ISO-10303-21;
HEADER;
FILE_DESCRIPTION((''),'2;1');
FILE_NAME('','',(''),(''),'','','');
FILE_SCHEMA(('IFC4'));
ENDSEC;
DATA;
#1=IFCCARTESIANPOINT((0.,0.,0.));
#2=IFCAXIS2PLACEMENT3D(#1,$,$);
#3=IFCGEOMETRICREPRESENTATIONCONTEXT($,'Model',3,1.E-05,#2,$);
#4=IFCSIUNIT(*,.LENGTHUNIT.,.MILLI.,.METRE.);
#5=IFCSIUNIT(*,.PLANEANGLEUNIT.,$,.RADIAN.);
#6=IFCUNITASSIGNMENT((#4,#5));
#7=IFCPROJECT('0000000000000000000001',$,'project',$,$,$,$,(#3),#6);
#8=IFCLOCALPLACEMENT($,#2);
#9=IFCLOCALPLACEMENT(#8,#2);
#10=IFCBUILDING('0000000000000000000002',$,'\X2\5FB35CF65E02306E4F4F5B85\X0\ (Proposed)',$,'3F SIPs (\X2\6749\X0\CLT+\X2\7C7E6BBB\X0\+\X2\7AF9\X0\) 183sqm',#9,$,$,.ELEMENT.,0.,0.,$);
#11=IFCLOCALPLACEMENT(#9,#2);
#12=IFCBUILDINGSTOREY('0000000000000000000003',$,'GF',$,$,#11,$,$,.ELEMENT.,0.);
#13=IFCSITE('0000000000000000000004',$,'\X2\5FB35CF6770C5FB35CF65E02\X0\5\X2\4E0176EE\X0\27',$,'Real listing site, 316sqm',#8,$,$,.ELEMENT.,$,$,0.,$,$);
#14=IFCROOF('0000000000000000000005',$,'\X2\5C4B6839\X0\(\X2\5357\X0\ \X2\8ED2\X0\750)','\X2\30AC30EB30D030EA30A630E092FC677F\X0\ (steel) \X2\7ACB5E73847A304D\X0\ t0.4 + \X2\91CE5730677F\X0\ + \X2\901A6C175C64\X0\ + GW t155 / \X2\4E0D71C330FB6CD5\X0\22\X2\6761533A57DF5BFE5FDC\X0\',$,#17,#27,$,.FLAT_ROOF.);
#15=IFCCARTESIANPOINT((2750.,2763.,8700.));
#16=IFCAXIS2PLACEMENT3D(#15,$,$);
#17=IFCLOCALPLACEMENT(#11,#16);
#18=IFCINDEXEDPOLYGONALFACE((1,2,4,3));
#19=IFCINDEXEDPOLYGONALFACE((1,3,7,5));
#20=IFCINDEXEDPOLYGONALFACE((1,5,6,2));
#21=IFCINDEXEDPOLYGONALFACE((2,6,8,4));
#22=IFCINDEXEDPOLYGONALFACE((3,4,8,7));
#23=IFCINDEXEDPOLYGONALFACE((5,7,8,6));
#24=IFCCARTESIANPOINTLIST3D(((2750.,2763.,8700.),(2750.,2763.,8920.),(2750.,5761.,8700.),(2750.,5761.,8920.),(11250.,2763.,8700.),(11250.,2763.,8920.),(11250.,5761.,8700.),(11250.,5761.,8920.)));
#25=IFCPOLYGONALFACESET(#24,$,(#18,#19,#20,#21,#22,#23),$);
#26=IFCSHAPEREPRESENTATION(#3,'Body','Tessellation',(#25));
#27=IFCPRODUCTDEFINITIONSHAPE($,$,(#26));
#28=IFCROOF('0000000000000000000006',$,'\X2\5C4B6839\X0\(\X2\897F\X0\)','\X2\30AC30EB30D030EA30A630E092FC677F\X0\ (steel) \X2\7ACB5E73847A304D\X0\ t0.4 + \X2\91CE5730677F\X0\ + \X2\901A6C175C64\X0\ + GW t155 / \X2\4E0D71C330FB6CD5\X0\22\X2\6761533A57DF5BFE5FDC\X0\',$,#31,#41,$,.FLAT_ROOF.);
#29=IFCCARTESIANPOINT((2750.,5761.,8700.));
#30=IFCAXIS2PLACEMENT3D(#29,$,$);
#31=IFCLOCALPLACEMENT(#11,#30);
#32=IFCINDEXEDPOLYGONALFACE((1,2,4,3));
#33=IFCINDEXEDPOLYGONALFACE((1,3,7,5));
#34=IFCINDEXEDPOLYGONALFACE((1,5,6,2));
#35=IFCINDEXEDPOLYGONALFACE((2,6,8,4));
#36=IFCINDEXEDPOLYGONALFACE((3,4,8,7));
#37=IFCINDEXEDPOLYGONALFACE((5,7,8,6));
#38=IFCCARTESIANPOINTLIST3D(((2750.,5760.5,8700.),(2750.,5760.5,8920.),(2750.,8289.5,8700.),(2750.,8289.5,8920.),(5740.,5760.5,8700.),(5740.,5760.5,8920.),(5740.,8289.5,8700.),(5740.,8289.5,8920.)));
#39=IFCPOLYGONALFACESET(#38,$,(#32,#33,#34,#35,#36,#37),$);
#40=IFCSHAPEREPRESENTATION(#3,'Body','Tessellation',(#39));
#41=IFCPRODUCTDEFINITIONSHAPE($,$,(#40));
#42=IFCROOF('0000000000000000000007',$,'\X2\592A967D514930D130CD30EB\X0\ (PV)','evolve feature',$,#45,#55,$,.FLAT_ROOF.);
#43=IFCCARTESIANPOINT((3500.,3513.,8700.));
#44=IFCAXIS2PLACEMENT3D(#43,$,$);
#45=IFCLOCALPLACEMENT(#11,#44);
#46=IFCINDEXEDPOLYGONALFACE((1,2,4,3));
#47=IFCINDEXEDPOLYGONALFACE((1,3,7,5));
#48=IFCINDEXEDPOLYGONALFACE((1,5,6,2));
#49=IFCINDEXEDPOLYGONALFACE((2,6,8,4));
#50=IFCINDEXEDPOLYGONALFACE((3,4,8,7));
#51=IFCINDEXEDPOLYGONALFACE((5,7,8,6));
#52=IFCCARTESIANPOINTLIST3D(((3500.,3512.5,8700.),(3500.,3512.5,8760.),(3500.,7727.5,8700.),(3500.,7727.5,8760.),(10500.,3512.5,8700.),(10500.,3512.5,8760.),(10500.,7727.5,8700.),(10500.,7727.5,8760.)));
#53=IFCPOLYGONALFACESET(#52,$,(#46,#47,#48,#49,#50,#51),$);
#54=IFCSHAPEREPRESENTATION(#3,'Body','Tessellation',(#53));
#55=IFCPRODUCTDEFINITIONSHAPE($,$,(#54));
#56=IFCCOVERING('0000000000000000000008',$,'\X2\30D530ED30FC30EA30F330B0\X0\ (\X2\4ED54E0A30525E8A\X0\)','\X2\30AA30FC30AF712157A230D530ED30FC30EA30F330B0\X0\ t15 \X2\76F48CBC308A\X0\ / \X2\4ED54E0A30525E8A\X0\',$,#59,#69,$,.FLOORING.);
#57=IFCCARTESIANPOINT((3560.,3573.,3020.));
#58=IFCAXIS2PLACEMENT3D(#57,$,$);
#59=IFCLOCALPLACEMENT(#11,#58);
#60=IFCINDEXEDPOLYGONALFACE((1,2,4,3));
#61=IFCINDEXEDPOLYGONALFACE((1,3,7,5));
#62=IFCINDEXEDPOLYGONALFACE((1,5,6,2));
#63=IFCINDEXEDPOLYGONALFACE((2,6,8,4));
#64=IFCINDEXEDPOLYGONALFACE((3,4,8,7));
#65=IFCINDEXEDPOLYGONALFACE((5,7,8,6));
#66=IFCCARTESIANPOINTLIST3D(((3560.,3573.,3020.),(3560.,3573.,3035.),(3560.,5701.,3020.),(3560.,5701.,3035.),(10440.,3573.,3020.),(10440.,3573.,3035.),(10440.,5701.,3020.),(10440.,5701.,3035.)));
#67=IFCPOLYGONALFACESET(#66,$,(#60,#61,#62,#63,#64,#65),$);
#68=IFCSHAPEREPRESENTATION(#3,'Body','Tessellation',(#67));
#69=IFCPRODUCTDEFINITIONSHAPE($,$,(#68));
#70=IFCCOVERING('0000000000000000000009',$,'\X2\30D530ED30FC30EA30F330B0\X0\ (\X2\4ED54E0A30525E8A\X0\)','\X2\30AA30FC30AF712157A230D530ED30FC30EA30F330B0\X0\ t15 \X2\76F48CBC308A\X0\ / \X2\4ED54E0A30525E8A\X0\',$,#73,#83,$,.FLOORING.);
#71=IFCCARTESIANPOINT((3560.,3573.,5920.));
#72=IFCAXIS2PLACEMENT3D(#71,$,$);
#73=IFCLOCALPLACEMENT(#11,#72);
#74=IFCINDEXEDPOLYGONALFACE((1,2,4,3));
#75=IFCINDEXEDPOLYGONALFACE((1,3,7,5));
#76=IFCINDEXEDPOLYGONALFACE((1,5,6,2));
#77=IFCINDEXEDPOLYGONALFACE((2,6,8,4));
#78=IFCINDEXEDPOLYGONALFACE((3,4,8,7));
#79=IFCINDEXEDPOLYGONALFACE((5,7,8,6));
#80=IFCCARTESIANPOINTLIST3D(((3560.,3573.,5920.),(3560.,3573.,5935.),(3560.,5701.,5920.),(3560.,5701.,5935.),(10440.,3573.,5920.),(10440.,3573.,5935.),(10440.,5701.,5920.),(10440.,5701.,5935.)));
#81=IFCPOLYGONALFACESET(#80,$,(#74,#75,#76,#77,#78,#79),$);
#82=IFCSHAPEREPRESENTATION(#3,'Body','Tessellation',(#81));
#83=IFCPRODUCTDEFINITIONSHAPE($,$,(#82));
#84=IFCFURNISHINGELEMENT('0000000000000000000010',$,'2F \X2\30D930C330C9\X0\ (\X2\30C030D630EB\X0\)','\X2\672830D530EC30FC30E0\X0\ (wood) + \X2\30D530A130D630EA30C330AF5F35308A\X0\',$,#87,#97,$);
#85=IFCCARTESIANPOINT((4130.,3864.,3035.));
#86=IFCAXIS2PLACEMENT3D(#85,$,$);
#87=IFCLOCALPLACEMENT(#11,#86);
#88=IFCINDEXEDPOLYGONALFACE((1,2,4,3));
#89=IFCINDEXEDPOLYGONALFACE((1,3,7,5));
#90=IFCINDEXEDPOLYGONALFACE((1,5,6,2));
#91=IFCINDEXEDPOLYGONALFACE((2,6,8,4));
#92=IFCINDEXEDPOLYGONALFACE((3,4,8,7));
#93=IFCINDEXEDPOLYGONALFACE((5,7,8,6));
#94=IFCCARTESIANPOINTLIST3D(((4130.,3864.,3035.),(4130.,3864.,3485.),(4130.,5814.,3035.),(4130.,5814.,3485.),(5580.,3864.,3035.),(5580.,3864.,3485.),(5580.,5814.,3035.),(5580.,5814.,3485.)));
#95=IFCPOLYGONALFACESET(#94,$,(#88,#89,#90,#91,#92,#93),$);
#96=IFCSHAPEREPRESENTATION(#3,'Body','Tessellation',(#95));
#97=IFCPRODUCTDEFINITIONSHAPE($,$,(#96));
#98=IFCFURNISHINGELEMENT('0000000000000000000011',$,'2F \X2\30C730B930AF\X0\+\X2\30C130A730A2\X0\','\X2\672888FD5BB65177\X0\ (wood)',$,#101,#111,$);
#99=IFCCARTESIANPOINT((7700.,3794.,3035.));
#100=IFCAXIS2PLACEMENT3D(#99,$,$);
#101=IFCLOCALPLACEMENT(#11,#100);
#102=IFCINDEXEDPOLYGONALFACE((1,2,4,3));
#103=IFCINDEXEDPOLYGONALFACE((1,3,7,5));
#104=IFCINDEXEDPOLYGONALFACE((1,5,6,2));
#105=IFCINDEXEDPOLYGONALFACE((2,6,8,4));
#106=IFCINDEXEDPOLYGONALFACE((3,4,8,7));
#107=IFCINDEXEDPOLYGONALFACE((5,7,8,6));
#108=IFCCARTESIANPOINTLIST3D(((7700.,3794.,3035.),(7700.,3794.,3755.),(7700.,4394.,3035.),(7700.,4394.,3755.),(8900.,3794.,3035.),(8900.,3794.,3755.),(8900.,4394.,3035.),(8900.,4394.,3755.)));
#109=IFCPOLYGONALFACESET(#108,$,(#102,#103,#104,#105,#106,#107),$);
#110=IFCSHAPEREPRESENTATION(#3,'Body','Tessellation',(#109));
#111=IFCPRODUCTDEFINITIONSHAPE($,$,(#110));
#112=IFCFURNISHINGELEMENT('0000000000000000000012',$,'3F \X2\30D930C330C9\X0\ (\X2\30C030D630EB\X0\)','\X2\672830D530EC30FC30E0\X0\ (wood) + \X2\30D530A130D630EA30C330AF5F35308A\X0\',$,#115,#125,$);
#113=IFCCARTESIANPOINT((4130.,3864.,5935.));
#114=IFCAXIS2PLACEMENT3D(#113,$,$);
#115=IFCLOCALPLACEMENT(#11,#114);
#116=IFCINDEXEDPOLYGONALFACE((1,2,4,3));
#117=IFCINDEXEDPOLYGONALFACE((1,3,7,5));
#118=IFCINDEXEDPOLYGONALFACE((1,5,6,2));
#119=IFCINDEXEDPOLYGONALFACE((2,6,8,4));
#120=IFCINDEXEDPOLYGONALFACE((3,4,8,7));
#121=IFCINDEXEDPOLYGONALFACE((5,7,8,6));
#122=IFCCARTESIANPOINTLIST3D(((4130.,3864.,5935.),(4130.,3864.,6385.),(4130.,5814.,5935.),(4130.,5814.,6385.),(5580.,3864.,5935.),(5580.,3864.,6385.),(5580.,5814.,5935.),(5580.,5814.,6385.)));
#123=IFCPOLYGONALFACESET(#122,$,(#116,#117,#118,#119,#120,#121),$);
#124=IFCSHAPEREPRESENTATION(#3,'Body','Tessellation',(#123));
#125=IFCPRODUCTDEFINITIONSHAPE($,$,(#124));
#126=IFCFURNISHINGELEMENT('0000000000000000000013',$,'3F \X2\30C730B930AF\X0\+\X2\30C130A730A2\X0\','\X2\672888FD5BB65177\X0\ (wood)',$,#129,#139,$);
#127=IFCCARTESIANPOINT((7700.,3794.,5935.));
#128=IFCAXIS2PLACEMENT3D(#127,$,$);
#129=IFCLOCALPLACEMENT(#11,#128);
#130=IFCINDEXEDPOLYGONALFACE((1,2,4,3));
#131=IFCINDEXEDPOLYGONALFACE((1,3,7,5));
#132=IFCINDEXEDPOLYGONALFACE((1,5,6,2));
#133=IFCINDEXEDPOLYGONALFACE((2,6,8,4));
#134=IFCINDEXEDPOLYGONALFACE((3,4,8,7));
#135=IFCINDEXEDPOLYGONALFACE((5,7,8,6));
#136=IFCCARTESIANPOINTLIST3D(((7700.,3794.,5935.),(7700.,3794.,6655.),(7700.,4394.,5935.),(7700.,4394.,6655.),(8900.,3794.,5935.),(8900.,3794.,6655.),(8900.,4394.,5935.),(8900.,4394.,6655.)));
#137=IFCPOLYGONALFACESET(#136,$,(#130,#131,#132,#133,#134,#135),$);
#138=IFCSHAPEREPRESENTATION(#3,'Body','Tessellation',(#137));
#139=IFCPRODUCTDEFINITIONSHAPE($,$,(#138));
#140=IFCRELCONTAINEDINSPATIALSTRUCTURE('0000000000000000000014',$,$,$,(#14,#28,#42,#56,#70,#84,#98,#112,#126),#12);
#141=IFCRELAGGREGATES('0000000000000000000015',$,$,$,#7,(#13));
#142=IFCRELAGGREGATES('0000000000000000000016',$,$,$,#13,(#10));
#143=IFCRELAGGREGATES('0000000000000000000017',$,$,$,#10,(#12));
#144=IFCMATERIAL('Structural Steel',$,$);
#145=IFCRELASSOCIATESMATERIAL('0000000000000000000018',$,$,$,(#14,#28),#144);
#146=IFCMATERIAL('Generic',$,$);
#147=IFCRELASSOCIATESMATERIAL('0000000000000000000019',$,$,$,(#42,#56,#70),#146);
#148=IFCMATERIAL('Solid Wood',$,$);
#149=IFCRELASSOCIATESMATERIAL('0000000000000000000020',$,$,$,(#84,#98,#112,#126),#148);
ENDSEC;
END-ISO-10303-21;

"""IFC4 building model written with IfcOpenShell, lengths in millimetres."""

from ifc_helpers import new_model, si_unit, frame, frame_2d, origin, place, context, project, spatial, rectangle, extrude, material, element, save


model = new_model("IFC4")

# Units and contexts
model_context = context("Model", 3, precision=1e-05, world=origin())
ifc_project = project(units=[si_unit("LENGTHUNIT", "METRE", prefix="MILLI"), si_unit("PLANEANGLEUNIT", "RADIAN")], contexts=[model_context])

# Site, building, storey
site_placement = place(None, origin())
site = spatial("IfcSite", under=ifc_project, at=site_placement, Name="徳島県徳島市5丁目27", ObjectType="Real listing site, 316sqm", CompositionType="ELEMENT", RefElevation=0.0)
building_placement = place(site_placement, origin())
building = spatial("IfcBuilding", under=site, at=building_placement, Name="徳島市の住宅 (Proposed)", ObjectType="3F SIPs (杉CLT+籾殻+竹) 183sqm", CompositionType="ELEMENT", ElevationOfRefHeight=0.0, ElevationOfTerrain=0.0)
storey_placement = place(building_placement, origin())
storey = spatial("IfcBuildingStorey", under=building, at=storey_placement, Name="GF", CompositionType="ELEMENT", Elevation=0.0)

# Shared definitions
ifc_material_1 = material(Name="Solid Wood")

# Roofs
ifc_material_2 = material(Name="Structural Steel")
roof_1_placement = place(storey_placement, frame((2750.0, 2763.0, 8700.0)))
element("IfcRoof", 1, at=roof_1_placement, inside=storey, material=ifc_material_2, Name="屋根(南 軒750)", Description="ガルバリウム鋼板 (steel) 立平葺き t0.4 + 野地板 + 通気層 + GW t155 / 不燃・法22条区域対応", PredefinedType="FLAT_ROOF", context=model_context, shape_type="SweptSolid", body=[
    extrude(rectangle(XDim=8500.0, YDim=2998.0, at=frame_2d((4250.0, 1499.0))), frame((2750.0, 2763.0, 8700.0)), (0.0, 0.0, 1.0), 220.0),
])
roof_2_placement = place(storey_placement, frame((2750.0, 5761.0, 8700.0)))
element("IfcRoof", 2, at=roof_2_placement, inside=storey, material=ifc_material_2, Name="屋根(西)", Description="ガルバリウム鋼板 (steel) 立平葺き t0.4 + 野地板 + 通気層 + GW t155 / 不燃・法22条区域対応", PredefinedType="FLAT_ROOF", context=model_context, shape_type="SweptSolid", body=[
    extrude(rectangle(XDim=2990.0, YDim=2529.0, at=frame_2d((1495.0, 1264.0))), frame((2750.0, 5761.0, 8700.0)), (0.0, 0.0, 1.0), 220.0),
])
ifc_material_3 = material(Name="Generic")
roof_3_placement = place(storey_placement, frame((3500.0, 3513.0, 8700.0)))
element("IfcRoof", 3, at=roof_3_placement, inside=storey, material=ifc_material_3, Name="太陽光パネル (PV)", Description="evolve feature", PredefinedType="FLAT_ROOF", context=model_context, shape_type="SweptSolid", body=[
    extrude(rectangle(XDim=7000.0, YDim=4215.0, at=frame_2d((3500.0, 2107.0))), frame((3500.0, 3513.0, 8700.0)), (0.0, 0.0, 1.0), 60.0),
])

# Coverings
covering_1_placement = place(storey_placement, frame((3560.0, 3573.0, 3020.0)))
element("IfcCovering", 4, at=covering_1_placement, inside=storey, material=ifc_material_3, Name="フローリング (仕上げ床)", Description="オーク無垢フローリング t15 直貼り / 仕上げ床", PredefinedType="FLOORING", context=model_context, shape_type="SweptSolid", body=[
    extrude(rectangle(XDim=6880.0, YDim=2128.0, at=frame_2d((3440.0, 1064.0))), frame((3560.0, 3573.0, 3020.0)), (0.0, 0.0, 1.0), 15.0),
])
covering_2_placement = place(storey_placement, frame((3560.0, 3573.0, 5920.0)))
element("IfcCovering", 5, at=covering_2_placement, inside=storey, material=ifc_material_3, Name="フローリング (仕上げ床)", Description="オーク無垢フローリング t15 直貼り / 仕上げ床", PredefinedType="FLOORING", context=model_context, shape_type="SweptSolid", body=[
    extrude(rectangle(XDim=6880.0, YDim=2128.0, at=frame_2d((3440.0, 1064.0))), frame((3560.0, 3573.0, 5920.0)), (0.0, 0.0, 1.0), 15.0),
])

# Furnishing elements
furnishing_1_placement = place(storey_placement, frame((4130.0, 3864.0, 3035.0)))
element("IfcFurnishingElement", 6, at=furnishing_1_placement, inside=storey, material=ifc_material_1, Name="2F ベッド (ダブル)", Description="木フレーム (wood) + ファブリック張り", context=model_context, shape_type="SweptSolid", body=[
    extrude(rectangle(XDim=1450.0, YDim=1950.0, at=frame_2d((725.0, 975.0))), frame((4130.0, 3864.0, 3035.0)), (0.0, 0.0, 1.0), 450.0),
])
furnishing_2_placement = place(storey_placement, frame((7700.0, 3794.0, 3035.0)))
element("IfcFurnishingElement", 7, at=furnishing_2_placement, inside=storey, material=ifc_material_1, Name="2F デスク+チェア", Description="木製家具 (wood)", context=model_context, shape_type="SweptSolid", body=[
    extrude(rectangle(XDim=1200.0, YDim=600.0, at=frame_2d((600.0, 300.0))), frame((7700.0, 3794.0, 3035.0)), (0.0, 0.0, 1.0), 720.0),
])
furnishing_3_placement = place(storey_placement, frame((4130.0, 3864.0, 5935.0)))
element("IfcFurnishingElement", 8, at=furnishing_3_placement, inside=storey, material=ifc_material_1, Name="3F ベッド (ダブル)", Description="木フレーム (wood) + ファブリック張り", context=model_context, shape_type="SweptSolid", body=[
    extrude(rectangle(XDim=1450.0, YDim=1950.0, at=frame_2d((725.0, 975.0))), frame((4130.0, 3864.0, 5935.0)), (0.0, 0.0, 1.0), 450.0),
])
furnishing_4_placement = place(storey_placement, frame((7700.0, 3794.0, 5935.0)))
element("IfcFurnishingElement", 9, at=furnishing_4_placement, inside=storey, material=ifc_material_1, Name="3F デスク+チェア", Description="木製家具 (wood)", context=model_context, shape_type="SweptSolid", body=[
    extrude(rectangle(XDim=1200.0, YDim=600.0, at=frame_2d((600.0, 300.0))), frame((7700.0, 3794.0, 5935.0)), (0.0, 0.0, 1.0), 720.0),
])

save(model, "model.ifc")
